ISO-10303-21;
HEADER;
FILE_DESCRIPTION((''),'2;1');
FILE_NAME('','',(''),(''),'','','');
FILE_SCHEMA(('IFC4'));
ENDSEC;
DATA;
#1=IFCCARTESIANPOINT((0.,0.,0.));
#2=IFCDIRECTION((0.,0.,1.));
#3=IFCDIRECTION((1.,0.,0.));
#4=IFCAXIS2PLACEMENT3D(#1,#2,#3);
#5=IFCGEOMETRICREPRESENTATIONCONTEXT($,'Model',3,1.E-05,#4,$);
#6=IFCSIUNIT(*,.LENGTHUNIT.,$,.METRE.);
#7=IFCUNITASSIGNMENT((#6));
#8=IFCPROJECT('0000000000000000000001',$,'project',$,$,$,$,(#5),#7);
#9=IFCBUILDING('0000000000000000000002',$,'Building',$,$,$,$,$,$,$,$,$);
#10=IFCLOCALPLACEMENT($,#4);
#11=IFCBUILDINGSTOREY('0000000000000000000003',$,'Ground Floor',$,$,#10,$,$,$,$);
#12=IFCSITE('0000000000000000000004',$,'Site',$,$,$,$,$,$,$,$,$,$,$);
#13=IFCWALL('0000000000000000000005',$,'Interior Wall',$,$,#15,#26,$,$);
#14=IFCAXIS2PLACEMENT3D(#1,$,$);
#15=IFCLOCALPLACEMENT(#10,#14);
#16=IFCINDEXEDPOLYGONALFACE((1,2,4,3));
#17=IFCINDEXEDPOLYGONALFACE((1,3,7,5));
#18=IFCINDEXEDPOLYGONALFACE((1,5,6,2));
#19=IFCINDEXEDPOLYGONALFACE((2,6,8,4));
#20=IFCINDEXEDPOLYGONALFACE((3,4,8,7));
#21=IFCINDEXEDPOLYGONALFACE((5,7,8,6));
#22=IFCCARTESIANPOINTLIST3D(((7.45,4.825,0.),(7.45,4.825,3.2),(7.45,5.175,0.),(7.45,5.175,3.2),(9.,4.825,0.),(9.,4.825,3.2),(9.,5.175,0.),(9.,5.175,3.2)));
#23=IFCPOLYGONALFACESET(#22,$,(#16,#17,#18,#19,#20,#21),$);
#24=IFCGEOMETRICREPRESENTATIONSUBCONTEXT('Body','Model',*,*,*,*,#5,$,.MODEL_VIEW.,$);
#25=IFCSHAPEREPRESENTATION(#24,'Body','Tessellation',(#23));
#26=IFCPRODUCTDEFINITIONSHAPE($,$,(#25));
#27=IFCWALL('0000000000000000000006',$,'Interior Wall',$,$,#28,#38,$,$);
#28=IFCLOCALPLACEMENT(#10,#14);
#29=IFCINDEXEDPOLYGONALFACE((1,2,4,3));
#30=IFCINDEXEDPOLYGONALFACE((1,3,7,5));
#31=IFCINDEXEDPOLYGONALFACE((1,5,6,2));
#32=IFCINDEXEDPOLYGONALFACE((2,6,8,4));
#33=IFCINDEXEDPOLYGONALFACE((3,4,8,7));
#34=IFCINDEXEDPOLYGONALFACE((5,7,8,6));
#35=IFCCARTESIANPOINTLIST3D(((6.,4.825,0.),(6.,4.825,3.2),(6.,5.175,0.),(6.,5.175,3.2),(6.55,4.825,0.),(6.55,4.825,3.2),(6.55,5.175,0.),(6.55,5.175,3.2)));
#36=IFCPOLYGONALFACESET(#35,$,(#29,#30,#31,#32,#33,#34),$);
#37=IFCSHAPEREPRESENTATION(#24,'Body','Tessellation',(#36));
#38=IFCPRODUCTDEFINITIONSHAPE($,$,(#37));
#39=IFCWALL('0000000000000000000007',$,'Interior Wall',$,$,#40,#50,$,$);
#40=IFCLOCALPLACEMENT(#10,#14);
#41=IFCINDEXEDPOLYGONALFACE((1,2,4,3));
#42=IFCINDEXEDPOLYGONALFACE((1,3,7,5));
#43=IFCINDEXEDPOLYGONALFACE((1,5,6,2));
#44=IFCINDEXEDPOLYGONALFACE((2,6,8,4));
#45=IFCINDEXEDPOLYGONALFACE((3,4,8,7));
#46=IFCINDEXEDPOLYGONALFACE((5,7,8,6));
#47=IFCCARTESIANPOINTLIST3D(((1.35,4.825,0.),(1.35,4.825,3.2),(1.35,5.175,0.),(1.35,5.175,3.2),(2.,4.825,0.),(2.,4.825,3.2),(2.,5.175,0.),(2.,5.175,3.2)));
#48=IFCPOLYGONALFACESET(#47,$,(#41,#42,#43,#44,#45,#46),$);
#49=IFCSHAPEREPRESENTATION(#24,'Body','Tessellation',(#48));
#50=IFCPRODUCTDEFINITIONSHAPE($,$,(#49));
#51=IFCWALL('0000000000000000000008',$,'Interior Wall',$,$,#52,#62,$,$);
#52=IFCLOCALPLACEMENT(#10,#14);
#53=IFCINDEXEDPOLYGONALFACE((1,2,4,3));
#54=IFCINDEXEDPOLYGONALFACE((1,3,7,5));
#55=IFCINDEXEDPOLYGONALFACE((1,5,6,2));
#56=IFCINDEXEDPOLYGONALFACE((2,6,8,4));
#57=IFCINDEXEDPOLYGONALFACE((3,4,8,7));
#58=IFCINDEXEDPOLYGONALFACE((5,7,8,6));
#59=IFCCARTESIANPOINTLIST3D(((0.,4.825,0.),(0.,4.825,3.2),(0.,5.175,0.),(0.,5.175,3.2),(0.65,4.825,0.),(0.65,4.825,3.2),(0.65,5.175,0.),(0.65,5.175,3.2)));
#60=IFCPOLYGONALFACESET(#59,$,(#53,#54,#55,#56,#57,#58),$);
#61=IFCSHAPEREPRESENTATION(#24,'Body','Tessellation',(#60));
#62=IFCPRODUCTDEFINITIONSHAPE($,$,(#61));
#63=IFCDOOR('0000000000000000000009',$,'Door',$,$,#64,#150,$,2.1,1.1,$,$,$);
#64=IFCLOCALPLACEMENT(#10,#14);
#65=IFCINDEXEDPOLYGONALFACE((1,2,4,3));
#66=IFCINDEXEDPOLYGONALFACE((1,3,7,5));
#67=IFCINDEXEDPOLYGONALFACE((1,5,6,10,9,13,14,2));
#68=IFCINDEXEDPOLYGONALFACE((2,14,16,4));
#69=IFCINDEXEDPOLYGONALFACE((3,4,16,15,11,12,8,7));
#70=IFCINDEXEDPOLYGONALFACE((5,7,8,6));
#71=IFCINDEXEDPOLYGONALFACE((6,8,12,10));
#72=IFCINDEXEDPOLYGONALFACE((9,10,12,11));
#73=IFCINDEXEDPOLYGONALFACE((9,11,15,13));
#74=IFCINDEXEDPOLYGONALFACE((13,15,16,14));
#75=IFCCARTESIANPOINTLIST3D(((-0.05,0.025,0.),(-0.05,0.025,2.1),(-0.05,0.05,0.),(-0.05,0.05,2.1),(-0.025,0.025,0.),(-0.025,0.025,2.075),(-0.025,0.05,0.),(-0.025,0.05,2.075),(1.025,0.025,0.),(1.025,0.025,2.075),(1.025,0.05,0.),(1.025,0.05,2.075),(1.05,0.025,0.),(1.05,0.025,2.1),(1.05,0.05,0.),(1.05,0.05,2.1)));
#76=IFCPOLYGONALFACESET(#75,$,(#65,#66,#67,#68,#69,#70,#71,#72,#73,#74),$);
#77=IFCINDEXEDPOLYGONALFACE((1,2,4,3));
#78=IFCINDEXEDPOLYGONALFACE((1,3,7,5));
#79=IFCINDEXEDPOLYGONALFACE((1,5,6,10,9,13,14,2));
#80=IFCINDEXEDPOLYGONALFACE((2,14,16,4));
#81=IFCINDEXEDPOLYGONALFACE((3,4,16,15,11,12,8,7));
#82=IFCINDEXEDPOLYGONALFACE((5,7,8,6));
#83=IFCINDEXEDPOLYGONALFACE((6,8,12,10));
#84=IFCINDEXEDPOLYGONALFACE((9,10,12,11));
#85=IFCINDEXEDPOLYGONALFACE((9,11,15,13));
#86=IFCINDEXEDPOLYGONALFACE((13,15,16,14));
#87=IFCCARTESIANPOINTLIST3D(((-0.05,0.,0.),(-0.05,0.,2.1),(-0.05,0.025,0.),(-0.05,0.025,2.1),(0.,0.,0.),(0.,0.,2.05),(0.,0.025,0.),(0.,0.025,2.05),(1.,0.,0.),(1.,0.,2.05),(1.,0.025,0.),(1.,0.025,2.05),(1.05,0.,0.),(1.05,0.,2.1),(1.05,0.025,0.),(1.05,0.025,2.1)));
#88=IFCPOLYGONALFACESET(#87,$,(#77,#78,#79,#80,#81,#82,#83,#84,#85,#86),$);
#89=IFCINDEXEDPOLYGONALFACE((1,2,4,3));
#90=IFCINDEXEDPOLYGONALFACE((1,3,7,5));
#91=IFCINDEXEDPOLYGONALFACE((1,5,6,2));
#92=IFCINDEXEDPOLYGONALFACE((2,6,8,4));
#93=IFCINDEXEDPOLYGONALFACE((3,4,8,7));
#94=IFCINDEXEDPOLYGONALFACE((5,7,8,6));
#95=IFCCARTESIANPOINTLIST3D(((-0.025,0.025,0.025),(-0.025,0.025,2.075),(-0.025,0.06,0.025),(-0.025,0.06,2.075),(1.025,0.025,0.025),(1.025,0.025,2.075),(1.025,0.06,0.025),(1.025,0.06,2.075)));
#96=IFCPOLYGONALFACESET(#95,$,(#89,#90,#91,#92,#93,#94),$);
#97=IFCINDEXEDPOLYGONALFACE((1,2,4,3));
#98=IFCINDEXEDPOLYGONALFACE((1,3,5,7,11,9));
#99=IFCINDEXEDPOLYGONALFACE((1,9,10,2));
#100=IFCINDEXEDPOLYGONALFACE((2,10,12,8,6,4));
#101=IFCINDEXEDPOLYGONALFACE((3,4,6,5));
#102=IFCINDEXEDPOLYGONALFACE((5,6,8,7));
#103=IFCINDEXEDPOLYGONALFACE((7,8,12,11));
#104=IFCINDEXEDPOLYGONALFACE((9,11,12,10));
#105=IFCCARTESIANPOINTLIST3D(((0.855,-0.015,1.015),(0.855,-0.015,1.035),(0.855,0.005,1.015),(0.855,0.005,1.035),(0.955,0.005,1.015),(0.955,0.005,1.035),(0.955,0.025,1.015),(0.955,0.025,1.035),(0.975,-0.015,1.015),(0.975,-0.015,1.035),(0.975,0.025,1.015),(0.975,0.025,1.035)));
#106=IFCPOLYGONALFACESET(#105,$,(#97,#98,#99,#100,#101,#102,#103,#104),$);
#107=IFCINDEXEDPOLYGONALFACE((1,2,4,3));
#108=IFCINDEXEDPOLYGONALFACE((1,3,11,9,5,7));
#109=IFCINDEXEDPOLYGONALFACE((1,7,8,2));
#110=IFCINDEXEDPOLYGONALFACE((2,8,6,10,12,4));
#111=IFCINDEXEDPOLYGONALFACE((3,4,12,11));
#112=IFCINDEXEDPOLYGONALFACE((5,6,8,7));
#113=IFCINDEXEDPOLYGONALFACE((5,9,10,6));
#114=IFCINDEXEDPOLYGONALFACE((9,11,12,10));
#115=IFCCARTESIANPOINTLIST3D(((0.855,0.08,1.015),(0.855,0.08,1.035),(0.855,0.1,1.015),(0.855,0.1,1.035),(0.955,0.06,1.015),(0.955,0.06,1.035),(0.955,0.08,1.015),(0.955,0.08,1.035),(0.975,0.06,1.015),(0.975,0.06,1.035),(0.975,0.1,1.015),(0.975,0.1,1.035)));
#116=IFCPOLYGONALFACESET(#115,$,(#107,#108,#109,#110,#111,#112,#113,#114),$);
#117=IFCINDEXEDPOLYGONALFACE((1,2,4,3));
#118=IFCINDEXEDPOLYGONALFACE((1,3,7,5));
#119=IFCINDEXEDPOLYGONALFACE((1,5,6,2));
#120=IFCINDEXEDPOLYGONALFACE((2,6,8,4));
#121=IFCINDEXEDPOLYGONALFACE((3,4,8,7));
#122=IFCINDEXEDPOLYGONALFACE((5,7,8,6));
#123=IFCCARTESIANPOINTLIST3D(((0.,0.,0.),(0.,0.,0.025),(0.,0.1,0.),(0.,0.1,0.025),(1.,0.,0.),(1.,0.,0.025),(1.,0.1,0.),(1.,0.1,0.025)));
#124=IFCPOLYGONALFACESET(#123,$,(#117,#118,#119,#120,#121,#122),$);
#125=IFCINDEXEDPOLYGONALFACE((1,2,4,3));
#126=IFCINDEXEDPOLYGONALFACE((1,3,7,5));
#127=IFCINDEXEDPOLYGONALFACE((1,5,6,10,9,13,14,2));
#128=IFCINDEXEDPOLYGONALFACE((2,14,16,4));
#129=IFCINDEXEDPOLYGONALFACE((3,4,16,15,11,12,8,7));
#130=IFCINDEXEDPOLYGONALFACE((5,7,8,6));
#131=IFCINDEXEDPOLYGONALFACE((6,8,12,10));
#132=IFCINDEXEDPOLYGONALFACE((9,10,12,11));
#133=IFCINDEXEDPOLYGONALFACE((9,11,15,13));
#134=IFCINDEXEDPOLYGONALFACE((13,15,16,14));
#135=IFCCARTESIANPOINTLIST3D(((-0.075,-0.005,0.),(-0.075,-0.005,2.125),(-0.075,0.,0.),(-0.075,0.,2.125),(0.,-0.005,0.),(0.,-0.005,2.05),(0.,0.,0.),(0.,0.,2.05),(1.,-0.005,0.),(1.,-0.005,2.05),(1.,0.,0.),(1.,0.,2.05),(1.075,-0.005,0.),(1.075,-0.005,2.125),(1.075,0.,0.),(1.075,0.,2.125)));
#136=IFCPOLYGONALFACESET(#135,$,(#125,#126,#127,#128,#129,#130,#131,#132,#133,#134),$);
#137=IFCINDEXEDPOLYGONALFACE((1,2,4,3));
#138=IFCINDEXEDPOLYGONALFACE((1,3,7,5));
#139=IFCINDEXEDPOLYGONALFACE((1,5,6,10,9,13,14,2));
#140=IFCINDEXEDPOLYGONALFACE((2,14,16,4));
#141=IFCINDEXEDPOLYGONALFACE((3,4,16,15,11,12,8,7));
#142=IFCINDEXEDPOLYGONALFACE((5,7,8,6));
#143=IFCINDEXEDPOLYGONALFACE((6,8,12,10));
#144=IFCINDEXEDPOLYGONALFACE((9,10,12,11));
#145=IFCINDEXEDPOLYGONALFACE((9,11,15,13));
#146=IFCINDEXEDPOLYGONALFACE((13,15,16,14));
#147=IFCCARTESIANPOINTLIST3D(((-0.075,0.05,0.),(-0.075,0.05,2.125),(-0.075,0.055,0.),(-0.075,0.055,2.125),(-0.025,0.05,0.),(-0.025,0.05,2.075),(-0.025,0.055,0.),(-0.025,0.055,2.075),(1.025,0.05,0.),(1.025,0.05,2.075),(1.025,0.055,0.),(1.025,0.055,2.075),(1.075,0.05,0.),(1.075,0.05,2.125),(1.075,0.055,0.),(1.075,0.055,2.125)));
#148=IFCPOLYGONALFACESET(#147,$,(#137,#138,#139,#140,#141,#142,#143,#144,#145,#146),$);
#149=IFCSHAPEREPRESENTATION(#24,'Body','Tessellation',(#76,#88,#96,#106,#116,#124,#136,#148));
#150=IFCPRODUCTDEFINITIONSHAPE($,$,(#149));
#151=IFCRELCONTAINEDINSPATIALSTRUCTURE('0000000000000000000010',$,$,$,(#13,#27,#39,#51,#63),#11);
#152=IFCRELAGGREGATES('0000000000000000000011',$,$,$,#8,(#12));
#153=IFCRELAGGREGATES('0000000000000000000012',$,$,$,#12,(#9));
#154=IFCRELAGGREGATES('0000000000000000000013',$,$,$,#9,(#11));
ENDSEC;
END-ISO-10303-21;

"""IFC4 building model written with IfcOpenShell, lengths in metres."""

from ifc_helpers import new_model, si_unit, frame, origin_with_axes, place, context, subcontext, project, spatial, line, indexed_curve, outline, extrude, element, save


model = new_model("IFC4")

# Units and contexts
model_context = context("Model", 3, precision=1e-05, world=origin_with_axes())
body_context = subcontext(model_context, "Body", "Model", "MODEL_VIEW")
ifc_project = project(units=[si_unit("LENGTHUNIT", "METRE")], contexts=[model_context])

# Site, building, storey
site = spatial("IfcSite", under=ifc_project, Name="Site")
building = spatial("IfcBuilding", under=site, Name="Building")
storey_placement = place(None, origin_with_axes())
storey = spatial("IfcBuildingStorey", under=building, at=storey_placement, Name="Ground Floor")

# Walls
wall_1_placement = place(storey_placement, frame((9.0, 5.0, 0.0), z_axis=(0.0, 0.0, 1.0), x_axis=(-1.0, 0.0, 0.0)))
element("IfcWall", 1, at=wall_1_placement, inside=storey, Name="Interior Wall", context=body_context, shape_type="SweptSolid", body=[
    extrude(outline(indexed_curve([(0.0, 0.0), (0.0, 0.35), (1.55, 0.35), (1.55, 0.0), (0.0, 0.0)], self_intersect=False)), frame((0.0, -0.175, 0.0), z_axis=(0.0, 0.0, 1.0), x_axis=(1.0, 0.0, 0.0)), (0.0, 0.0, 1.0), 3.2),
])
wall_2_placement = place(storey_placement, frame((6.55, 5.0, 0.0), z_axis=(0.0, 0.0, 1.0), x_axis=(-1.0, 0.0, 0.0)))
element("IfcWall", 2, at=wall_2_placement, inside=storey, Name="Interior Wall", context=body_context, shape_type="SweptSolid", body=[
    extrude(outline(indexed_curve([(0.0, 0.0), (0.0, 0.35), (0.55, 0.35), (0.55, 0.0), (0.0, 0.0)], self_intersect=False)), frame((0.0, -0.175, 0.0), z_axis=(0.0, 0.0, 1.0), x_axis=(1.0, 0.0, 0.0)), (0.0, 0.0, 1.0), 3.2),
])
for number, where, z_axis, x_axis, name in (
    (3, (2.0, 5.0, 0.0), (0.0, 0.0, 1.0), (-1.0, 0.0, 0.0), "Interior Wall"),
    (4, (0.65, 5.0, 0.0), (0.0, 0.0, 1.0), (-1.0, 0.0, 0.0), "Interior Wall"),
):
    element("IfcWall", number, at=place(storey_placement, frame(where, z_axis=z_axis, x_axis=x_axis)), inside=storey, Name=name, context=body_context, shape_type="SweptSolid", body=[
        extrude(outline(indexed_curve([(0.0, 0.0), (0.0, 0.35), (0.65, 0.35), (0.65, 0.0), (0.0, 0.0)], self_intersect=False)), frame((0.0, -0.175, 0.0), z_axis=(0.0, 0.0, 1.0), x_axis=(1.0, 0.0, 0.0)), (0.0, 0.0, 1.0), 3.2),
    ])

# Door
door_1_placement = place(storey_placement, frame((-0.05, 0.0, 0.0), z_axis=(0.0, 0.0, 1.0), x_axis=(1.0, 0.0, 0.0)))
element("IfcDoor", 5, at=door_1_placement, inside=storey, Name="Door", OverallHeight=2.1, OverallWidth=1.1, context=body_context, shape_type="SweptSolid", body=[
    extrude(outline(indexed_curve([(0.0, 0.0), (0.0, 2.1), (1.1, 2.1), (1.1, 0.0), (1.075, 0.0), (1.075, 2.075), (0.025, 2.075), (0.025, 0.0)], segments=[line(1, 2, 3, 4, 5, 6, 7, 8, 1)])), frame((0.0, 0.025, 0.0), z_axis=(0.0, -1.0, 0.0), x_axis=(1.0, 0.0, 0.0)), (0.0, 0.0, -1.0), 0.025),
    extrude(outline(indexed_curve([(0.0, 0.0), (0.0, 2.1), (1.1, 2.1), (1.1, 0.0), (1.05, 0.0), (1.05, 2.05), (0.05, 2.05), (0.05, 0.0)], segments=[line(1, 2, 3, 4, 5, 6, 7, 8, 1)])), frame((0.0, 0.0, 0.0), z_axis=(0.0, -1.0, 0.0), x_axis=(1.0, 0.0, 0.0)), (0.0, 0.0, -1.0), 0.025),
    extrude(outline(indexed_curve([(0.0, 0.0), (1.05, 0.0), (1.05, 0.035), (0.0, 0.035)], segments=[line(1, 2, 3, 4, 1)])), frame((0.025, 0.025, 0.025), z_axis=(0.0, 0.0, 1.0), x_axis=(1.0, 0.0, 0.0)), (0.0, 0.0, 1.0), 2.05),
    extrude(outline(indexed_curve([(0.0, 0.0), (0.0, -0.04), (-0.12, -0.04), (-0.12, -0.02), (-0.02, -0.02), (-0.02, 0.0)], segments=[line(1, 2, 3, 4, 5, 6, 1)])), frame((1.025, 0.025, 1.015), z_axis=(0.0, 0.0, 1.0), x_axis=(1.0, 0.0, 0.0)), (0.0, 0.0, 1.0), 0.02),
    extrude(outline(indexed_curve([(0.0, 0.0), (0.0, 0.04), (-0.12, 0.04), (-0.12, 0.02), (-0.02, 0.02), (-0.02, 0.0)], segments=[line(1, 2, 3, 4, 5, 6, 1)])), frame((1.025, 0.06, 1.015), z_axis=(0.0, 0.0, 1.0), x_axis=(1.0, 0.0, 0.0)), (0.0, 0.0, 1.0), 0.02),
    extrude(outline(indexed_curve([(0.0, 0.0), (1.0, 0.0), (1.0, 0.1), (0.0, 0.1)], segments=[line(1, 2, 3, 4, 1)])), frame((0.05, 0.0, 0.0), z_axis=(0.0, 0.0, 1.0), x_axis=(1.0, 0.0, 0.0)), (0.0, 0.0, 1.0), 0.025),
    extrude(outline(indexed_curve([(0.0, 0.0), (0.0, 2.125), (1.15, 2.125), (1.15, 0.0), (1.075, 0.0), (1.075, 2.05), (0.075, 2.05), (0.075, 0.0)], segments=[line(1, 2, 3, 4, 5, 6, 7, 8, 1)])), frame((-0.025, -0.005, 0.0), z_axis=(0.0, -1.0, 0.0), x_axis=(1.0, 0.0, 0.0)), (0.0, 0.0, -1.0), 0.005),
    extrude(outline(indexed_curve([(0.0, 0.0), (0.0, 2.125), (1.15, 2.125), (1.15, 0.0), (1.1, 0.0), (1.1, 2.075), (0.05, 2.075), (0.05, 0.0)], segments=[line(1, 2, 3, 4, 5, 6, 7, 8, 1)])), frame((-0.025, 0.05, 0.0), z_axis=(0.0, -1.0, 0.0), x_axis=(1.0, 0.0, 0.0)), (0.0, 0.0, -1.0), 0.005),
])

save(model, "model.ifc")
